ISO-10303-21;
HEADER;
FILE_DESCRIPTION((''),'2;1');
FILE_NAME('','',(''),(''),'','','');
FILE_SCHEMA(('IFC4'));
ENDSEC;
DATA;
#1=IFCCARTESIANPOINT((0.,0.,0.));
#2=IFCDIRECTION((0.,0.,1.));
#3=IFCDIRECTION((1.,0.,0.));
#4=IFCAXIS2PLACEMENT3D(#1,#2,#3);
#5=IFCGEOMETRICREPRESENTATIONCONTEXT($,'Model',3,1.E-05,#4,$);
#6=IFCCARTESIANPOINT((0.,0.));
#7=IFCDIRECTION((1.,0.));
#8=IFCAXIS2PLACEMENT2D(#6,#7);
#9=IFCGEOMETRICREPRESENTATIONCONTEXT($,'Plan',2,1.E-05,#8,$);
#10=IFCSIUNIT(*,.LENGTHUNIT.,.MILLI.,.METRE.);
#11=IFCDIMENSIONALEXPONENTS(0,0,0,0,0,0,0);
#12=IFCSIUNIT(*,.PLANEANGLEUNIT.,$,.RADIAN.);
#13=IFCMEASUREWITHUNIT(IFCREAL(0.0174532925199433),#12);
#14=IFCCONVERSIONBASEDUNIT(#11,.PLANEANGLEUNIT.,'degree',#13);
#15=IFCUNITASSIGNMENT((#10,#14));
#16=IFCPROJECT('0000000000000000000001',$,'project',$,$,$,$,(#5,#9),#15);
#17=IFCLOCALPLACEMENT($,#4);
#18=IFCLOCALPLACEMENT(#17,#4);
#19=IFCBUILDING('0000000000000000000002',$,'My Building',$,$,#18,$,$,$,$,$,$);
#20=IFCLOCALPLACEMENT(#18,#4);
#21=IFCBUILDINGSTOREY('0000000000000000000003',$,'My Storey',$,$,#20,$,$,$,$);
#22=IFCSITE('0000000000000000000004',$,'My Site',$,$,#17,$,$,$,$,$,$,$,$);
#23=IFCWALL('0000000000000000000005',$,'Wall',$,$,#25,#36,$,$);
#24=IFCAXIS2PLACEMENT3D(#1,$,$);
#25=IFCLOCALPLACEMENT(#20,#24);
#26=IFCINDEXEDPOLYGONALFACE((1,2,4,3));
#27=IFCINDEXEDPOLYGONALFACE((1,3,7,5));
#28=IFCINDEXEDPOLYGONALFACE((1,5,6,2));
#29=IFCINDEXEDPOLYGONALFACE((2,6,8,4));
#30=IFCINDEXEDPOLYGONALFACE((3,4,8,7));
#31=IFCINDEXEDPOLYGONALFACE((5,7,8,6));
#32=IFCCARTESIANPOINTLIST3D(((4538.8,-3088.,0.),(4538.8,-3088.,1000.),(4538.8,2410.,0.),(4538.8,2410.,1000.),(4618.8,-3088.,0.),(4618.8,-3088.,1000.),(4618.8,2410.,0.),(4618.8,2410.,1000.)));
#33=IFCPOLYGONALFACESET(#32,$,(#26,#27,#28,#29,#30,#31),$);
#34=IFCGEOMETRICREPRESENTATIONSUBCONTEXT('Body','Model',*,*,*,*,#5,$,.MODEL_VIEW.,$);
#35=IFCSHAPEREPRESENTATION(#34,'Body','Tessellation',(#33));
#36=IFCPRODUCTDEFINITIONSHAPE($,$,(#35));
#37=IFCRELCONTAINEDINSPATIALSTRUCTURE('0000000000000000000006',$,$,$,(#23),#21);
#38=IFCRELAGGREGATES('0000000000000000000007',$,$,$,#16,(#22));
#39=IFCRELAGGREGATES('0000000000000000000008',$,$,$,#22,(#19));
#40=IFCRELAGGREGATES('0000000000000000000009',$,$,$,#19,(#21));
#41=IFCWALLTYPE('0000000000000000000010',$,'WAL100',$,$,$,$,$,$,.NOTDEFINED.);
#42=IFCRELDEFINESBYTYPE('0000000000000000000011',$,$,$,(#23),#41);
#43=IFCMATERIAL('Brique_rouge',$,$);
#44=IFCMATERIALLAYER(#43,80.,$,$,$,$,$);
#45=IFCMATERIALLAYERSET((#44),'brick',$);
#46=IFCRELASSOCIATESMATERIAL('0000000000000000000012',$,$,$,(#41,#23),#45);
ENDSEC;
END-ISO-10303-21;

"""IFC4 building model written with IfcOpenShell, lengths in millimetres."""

from ifc_helpers import new_model, entity, si_unit, converted_unit, frame, origin_with_axes, origin_2d_with_axis, place, context, subcontext, project, spatial, indexed_curve, outline, extrude, material, layer, layer_set, layer_usage, type_object, element, save


model = new_model("IFC4")

# Units and contexts
model_context = context("Model", 3, precision=1e-05, world=origin_with_axes())
plan_context = context("Plan", 2, precision=1e-05, world=origin_2d_with_axis())
body_context_1 = subcontext(model_context, "Body", "Model", "MODEL_VIEW")
ifc_project = project(units=[si_unit("LENGTHUNIT", "METRE", prefix="MILLI"), converted_unit("PLANEANGLEUNIT", "degree", entity("IfcReal", 0.0174532925199433), si_unit("PLANEANGLEUNIT", "RADIAN"), dimensions=[0, 0, 0, 0, 0, 0, 0])], contexts=[model_context, plan_context])

# Site, building, storey
site_placement = place(None, origin_with_axes())
site = spatial("IfcSite", under=ifc_project, at=site_placement, Name="My Site")
building_placement = place(site_placement, origin_with_axes())
building = spatial("IfcBuilding", under=site, at=building_placement, Name="My Building")
storey_placement = place(building_placement, origin_with_axes())
storey = spatial("IfcBuildingStorey", under=building, at=storey_placement, Name="My Storey")

# Wall
ifc_material_1 = material(Name="Brique_rouge")
ifc_layer_1 = layer(ifc_material_1, 80.0)
ifc_layer_set_1 = layer_set([ifc_layer_1], Name="brick")
ifc_layer_usage_1 = layer_usage(ifc_layer_set_1, "AXIS2", "POSITIVE", 0.0)
wall_type = type_object("IfcWallType", Name="WAL100", PredefinedType="NOTDEFINED", material=ifc_layer_set_1)
wall_placement = place(storey_placement, frame((4618.8, -3088.0, 0.0), z_axis=(0.0, 0.0, 1.0), x_axis=(0.000002, 1.0, 0.0)))
element("IfcWall", 1, at=wall_placement, inside=storey, type_object=wall_type, material=ifc_layer_usage_1, Name="Wall", context=body_context_1, shape_type="SweptSolid", body=[
    extrude(outline(indexed_curve([(0.0, 0.0), (0.0, 80.0), (5498.0, 80.0), (5498.0, 0.0), (0.0, 0.0)], self_intersect=False)), origin_with_axes(), (0.0, 0.0, 1.0), 1000.0),
])

save(model, "model.ifc")
